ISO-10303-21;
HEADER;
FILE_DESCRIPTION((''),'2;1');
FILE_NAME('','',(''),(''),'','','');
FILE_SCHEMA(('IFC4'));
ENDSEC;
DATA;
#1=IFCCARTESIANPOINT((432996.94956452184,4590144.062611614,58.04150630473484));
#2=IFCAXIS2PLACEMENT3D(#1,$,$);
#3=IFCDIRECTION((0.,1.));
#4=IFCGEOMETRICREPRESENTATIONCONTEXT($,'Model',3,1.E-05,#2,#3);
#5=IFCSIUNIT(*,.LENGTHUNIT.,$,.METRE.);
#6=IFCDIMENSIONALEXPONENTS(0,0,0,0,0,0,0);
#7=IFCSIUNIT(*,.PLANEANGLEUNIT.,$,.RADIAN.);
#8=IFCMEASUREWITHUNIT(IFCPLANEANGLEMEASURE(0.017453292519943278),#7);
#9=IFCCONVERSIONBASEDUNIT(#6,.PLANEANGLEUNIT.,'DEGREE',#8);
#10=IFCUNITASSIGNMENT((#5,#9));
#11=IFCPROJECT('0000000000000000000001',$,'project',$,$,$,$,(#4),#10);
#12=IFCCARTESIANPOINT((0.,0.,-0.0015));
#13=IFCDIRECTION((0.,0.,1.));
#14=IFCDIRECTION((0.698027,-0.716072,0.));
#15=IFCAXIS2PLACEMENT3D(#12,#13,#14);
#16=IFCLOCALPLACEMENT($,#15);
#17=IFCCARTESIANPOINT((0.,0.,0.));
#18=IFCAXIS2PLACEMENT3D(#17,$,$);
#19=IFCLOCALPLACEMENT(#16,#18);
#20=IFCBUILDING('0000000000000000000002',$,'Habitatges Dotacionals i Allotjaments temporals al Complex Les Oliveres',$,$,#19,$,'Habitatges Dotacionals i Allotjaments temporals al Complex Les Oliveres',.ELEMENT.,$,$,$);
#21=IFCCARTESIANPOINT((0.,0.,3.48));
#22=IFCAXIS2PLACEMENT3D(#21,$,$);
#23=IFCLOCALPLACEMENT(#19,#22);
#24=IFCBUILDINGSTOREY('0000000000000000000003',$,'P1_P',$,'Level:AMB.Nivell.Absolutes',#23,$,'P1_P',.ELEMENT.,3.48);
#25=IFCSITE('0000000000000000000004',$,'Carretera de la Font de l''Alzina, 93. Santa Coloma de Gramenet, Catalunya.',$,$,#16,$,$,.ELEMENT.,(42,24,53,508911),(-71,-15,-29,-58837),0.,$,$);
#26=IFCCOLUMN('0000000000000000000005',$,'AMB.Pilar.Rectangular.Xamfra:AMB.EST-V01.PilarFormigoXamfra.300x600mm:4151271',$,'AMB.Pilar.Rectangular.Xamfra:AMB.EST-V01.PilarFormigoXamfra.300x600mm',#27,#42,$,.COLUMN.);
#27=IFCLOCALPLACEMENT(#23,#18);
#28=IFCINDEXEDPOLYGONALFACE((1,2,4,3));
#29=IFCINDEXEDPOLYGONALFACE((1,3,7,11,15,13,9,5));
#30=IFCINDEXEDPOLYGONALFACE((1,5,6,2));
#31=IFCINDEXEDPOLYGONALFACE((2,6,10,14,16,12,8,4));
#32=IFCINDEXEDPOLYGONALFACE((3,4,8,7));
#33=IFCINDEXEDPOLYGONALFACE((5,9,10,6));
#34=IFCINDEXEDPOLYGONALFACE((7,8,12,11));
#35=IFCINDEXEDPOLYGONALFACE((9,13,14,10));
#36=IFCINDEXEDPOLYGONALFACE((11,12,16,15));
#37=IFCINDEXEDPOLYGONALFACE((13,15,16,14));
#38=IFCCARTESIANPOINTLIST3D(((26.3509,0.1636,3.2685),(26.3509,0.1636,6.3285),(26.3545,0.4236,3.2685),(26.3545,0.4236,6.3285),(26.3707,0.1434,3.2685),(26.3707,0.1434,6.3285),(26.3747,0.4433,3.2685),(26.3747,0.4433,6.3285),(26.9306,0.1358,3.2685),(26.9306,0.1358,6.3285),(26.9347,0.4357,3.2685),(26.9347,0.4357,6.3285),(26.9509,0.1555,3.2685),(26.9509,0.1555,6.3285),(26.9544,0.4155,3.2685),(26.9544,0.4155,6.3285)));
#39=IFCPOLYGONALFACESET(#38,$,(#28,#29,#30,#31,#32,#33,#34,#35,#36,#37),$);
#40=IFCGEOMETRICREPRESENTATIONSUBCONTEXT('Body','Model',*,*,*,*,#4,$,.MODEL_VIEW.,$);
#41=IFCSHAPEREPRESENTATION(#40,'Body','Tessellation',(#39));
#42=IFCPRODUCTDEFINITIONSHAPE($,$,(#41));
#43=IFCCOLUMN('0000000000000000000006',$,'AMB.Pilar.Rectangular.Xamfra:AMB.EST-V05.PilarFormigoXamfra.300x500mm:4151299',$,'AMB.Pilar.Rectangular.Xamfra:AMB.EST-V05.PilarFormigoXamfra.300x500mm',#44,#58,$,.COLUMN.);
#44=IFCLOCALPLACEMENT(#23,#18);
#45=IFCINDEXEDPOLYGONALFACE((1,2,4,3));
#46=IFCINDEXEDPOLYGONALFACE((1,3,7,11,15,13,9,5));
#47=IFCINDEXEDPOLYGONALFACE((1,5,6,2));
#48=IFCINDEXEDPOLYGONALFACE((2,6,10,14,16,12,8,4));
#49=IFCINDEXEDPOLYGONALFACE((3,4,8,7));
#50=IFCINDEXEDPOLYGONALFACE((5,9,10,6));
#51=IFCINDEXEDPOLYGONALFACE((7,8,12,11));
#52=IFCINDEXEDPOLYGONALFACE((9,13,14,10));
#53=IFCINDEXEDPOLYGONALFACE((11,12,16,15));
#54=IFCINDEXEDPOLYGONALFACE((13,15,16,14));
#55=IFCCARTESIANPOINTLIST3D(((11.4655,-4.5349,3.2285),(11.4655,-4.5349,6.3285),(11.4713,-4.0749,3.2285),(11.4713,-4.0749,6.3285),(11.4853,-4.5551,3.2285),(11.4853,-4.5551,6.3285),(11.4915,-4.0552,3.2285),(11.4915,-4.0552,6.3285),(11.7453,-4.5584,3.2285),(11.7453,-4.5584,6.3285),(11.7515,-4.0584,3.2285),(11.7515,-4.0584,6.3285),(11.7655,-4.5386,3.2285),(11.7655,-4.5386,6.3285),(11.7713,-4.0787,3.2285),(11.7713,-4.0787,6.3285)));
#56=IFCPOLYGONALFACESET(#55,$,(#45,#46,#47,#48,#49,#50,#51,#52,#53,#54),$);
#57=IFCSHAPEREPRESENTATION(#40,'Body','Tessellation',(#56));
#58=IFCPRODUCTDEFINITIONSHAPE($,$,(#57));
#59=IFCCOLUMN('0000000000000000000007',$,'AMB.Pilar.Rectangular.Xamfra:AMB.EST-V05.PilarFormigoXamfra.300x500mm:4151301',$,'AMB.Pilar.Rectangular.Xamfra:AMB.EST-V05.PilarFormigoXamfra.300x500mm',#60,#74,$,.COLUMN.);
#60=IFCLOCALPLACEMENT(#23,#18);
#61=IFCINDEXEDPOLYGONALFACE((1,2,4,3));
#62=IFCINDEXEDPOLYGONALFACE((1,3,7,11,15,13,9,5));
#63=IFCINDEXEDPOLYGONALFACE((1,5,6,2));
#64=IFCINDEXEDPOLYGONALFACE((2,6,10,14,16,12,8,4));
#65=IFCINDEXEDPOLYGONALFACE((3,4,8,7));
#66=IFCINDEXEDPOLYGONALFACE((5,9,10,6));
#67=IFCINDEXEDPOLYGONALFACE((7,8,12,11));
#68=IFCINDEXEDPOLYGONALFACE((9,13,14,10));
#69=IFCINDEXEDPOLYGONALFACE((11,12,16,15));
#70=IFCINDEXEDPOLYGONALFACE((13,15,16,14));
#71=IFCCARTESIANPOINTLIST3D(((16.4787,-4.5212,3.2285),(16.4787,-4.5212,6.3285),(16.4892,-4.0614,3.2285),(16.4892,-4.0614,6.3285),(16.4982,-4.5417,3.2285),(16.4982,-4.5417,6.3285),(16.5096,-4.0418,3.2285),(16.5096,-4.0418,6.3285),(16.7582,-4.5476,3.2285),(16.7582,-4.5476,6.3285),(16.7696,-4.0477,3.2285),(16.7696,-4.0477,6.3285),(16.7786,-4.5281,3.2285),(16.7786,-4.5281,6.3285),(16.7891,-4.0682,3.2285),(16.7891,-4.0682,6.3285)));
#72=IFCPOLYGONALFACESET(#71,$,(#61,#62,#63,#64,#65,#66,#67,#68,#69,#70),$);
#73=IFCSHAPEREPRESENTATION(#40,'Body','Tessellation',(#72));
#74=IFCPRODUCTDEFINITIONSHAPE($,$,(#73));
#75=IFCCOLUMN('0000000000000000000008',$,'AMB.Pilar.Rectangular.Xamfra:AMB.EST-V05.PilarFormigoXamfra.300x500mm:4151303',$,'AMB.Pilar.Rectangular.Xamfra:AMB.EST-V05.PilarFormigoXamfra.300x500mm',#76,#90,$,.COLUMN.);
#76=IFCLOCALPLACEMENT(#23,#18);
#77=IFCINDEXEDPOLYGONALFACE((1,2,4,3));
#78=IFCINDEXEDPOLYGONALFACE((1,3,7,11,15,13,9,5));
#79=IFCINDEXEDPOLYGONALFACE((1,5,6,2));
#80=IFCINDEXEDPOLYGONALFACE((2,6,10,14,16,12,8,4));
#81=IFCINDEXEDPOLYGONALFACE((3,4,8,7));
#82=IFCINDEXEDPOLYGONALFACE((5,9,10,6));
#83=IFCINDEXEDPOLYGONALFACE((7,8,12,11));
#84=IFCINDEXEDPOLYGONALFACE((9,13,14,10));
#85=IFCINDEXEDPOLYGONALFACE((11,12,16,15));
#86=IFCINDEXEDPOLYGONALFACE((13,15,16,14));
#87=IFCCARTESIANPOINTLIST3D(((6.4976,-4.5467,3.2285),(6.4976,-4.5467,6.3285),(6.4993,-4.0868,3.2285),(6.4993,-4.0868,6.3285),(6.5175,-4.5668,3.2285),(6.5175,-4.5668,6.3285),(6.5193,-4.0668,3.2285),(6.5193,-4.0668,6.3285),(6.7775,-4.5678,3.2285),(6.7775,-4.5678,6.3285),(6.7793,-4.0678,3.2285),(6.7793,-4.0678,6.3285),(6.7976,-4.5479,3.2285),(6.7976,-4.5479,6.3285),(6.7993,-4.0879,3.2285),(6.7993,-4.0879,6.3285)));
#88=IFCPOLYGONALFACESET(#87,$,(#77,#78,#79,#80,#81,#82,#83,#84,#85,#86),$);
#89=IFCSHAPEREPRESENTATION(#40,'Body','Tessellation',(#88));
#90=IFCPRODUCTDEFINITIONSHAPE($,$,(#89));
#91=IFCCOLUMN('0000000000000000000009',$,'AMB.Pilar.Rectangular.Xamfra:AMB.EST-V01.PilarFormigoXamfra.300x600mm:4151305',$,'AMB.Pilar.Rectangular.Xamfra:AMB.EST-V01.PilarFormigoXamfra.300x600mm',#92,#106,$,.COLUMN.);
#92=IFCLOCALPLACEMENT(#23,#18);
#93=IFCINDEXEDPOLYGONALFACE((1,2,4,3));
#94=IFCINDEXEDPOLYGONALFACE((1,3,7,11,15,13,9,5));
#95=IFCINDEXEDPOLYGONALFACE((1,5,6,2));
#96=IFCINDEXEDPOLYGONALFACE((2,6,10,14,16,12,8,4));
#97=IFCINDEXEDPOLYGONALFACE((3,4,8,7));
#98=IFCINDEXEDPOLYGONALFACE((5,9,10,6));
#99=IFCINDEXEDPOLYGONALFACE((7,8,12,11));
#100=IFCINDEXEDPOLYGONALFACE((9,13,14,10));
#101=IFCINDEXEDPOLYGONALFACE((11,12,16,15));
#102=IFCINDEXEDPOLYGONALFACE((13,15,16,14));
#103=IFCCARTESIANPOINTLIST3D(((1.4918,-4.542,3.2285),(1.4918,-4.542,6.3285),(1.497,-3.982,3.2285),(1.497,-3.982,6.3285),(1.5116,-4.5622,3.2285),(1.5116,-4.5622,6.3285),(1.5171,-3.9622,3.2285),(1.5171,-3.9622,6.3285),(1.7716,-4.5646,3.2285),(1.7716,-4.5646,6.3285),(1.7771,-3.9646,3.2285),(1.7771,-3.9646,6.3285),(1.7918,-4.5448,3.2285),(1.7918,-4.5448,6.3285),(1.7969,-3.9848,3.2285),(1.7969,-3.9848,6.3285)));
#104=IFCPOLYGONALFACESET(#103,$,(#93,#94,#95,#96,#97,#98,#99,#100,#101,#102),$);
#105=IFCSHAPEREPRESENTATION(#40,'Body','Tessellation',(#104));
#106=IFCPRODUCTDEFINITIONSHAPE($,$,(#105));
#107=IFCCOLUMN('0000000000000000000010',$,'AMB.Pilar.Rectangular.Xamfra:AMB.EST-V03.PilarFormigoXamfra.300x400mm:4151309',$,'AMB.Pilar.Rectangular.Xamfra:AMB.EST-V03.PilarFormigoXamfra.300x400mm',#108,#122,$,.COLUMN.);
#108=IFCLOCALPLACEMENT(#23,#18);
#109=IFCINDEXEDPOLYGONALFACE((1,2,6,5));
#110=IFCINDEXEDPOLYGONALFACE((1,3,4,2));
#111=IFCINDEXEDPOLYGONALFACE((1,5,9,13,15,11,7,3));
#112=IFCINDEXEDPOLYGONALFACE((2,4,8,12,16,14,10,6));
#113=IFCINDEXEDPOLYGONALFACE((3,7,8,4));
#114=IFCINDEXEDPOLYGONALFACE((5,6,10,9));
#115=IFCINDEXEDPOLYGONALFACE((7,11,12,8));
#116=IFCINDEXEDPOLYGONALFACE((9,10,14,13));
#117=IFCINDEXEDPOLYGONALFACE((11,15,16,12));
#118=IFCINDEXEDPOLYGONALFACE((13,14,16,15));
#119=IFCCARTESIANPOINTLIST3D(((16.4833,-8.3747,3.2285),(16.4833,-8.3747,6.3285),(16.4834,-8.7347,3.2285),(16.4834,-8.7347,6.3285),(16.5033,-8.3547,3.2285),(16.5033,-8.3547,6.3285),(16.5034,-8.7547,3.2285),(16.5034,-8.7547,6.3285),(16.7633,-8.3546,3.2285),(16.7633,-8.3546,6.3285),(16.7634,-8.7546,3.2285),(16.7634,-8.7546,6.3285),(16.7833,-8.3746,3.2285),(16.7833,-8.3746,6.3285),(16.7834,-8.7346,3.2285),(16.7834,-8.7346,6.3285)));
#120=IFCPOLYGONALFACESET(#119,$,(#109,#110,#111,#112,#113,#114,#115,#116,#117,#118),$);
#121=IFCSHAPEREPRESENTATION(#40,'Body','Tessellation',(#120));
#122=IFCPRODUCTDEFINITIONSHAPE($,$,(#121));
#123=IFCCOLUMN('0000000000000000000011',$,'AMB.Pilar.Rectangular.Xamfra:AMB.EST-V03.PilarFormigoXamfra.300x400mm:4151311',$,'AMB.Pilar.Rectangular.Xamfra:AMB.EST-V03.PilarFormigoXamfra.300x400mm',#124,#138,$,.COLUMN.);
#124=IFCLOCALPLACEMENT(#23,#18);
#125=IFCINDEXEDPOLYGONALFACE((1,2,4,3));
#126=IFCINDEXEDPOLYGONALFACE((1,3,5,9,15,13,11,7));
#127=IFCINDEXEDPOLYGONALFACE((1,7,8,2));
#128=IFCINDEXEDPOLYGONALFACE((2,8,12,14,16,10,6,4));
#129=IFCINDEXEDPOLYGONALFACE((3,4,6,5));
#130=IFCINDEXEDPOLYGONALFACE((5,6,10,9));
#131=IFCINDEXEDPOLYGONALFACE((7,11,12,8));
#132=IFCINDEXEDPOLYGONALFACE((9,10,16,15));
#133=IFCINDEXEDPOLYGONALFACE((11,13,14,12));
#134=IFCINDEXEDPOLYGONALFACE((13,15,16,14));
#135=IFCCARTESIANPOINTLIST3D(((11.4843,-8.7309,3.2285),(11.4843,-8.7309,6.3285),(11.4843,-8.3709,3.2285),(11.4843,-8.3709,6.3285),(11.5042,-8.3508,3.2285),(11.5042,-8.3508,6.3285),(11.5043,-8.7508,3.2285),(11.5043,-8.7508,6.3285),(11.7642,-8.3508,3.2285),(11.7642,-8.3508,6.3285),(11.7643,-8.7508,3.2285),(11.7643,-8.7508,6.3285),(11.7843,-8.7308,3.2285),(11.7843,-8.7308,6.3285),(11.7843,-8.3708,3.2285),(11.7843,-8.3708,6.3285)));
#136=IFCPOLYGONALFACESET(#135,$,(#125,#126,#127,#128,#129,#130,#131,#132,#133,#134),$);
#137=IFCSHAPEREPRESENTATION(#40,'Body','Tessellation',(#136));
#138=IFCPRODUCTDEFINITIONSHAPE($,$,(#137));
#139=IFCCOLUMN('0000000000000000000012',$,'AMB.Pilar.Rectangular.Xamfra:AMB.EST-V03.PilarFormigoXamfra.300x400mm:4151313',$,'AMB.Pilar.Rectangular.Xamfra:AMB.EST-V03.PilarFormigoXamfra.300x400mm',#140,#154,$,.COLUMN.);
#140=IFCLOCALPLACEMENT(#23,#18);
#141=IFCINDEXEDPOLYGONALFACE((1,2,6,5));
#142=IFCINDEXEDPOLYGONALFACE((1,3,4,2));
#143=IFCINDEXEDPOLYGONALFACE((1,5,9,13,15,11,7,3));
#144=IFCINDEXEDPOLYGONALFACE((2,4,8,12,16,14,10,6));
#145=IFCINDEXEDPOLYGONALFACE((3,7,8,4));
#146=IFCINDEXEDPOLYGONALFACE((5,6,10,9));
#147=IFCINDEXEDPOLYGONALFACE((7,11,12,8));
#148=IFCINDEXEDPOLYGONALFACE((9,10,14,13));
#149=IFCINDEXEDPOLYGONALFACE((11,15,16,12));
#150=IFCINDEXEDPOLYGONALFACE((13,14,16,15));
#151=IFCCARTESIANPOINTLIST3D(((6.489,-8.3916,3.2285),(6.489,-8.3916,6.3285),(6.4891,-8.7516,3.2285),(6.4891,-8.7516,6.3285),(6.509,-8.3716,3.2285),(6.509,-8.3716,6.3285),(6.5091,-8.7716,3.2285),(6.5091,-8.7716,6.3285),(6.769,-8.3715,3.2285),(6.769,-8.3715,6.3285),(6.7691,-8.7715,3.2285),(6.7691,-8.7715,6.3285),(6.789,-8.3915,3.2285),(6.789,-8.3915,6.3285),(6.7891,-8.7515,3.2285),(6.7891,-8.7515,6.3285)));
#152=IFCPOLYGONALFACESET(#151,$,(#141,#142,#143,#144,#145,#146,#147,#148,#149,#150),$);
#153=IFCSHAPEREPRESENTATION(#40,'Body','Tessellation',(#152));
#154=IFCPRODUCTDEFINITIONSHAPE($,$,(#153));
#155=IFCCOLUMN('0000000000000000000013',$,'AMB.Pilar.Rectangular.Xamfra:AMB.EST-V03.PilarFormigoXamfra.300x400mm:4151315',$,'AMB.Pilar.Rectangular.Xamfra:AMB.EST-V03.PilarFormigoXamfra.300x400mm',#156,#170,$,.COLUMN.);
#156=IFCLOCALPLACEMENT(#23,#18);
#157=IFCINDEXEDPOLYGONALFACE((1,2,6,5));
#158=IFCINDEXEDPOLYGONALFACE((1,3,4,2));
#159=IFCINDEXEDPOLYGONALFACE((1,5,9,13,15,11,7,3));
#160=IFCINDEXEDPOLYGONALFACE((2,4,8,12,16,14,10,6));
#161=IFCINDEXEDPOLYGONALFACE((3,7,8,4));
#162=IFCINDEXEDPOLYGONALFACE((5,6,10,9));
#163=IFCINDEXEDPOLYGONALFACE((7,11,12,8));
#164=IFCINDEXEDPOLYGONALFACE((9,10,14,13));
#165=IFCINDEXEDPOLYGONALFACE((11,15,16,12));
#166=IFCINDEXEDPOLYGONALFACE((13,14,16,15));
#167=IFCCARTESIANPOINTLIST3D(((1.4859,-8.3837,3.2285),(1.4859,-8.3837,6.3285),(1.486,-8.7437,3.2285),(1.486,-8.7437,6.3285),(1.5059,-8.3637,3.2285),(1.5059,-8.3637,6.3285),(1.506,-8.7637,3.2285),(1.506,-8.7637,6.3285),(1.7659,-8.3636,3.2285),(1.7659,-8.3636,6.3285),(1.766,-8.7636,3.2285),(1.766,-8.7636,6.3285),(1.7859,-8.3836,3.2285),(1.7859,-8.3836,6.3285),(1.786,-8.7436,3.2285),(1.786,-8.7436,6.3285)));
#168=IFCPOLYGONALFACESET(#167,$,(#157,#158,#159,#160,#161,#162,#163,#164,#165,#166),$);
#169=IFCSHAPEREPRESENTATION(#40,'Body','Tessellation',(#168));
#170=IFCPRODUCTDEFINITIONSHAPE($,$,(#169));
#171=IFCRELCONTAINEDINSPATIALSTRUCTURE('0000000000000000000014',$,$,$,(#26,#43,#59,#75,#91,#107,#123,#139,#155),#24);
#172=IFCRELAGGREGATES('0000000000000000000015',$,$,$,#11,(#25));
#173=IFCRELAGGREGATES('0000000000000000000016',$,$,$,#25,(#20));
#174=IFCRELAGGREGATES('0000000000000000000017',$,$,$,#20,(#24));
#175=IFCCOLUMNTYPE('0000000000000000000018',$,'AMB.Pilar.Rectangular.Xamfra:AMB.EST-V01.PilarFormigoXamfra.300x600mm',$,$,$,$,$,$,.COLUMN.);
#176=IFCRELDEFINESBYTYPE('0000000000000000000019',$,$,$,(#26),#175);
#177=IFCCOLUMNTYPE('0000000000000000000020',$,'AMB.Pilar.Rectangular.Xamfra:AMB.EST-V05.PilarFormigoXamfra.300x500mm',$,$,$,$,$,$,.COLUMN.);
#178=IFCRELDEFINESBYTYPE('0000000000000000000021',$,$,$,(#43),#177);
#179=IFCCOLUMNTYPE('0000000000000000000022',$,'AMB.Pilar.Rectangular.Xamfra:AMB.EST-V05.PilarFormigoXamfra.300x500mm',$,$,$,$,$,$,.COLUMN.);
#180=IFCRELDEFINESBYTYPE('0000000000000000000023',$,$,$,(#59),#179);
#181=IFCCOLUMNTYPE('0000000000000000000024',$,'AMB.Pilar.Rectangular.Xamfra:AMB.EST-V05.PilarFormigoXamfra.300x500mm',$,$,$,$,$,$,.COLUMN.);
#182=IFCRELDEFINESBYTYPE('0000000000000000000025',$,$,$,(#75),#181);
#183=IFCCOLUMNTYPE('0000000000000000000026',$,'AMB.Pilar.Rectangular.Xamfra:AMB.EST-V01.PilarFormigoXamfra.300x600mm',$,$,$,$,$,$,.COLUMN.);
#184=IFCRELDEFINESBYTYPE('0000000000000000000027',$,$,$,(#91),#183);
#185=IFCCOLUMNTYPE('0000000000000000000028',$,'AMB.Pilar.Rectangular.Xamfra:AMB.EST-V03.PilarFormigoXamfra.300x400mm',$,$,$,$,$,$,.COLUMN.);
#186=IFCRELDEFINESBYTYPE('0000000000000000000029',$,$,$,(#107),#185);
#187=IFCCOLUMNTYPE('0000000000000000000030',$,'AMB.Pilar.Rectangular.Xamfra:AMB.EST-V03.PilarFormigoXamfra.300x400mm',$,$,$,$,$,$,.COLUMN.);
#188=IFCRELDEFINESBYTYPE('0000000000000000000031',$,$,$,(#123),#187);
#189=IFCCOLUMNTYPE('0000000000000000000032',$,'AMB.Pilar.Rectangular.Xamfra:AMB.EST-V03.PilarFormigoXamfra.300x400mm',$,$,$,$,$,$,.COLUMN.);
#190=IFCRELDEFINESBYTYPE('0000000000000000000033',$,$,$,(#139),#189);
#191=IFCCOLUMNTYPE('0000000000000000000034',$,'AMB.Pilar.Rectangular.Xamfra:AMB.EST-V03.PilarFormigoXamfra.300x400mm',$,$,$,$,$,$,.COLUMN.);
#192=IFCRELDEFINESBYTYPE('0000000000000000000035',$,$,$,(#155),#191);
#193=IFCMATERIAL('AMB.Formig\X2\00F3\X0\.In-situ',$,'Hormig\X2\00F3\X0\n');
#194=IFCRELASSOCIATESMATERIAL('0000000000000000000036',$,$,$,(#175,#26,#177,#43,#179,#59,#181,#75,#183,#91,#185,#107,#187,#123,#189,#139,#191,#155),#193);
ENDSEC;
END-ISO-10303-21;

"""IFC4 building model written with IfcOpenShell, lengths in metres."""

from ifc_helpers import new_model, entity, si_unit, converted_unit, direction, frame, origin, place, context, subcontext, project, spatial, indexed_curve, outline, extrude, source, transform, mapped, material, type_object, type_shapes, element, save


model = new_model("IFC4")

# Units and contexts
model_context = context("Model", 3, precision=1e-05, world=frame((432996.94956452184, 4590144.062611614, 58.04150630473484)), true_north=direction((0.0, 1.0)))
body_context = subcontext(model_context, "Body", "Model", "MODEL_VIEW")
ifc_project = project(units=[si_unit("LENGTHUNIT", "METRE"), converted_unit("PLANEANGLEUNIT", "DEGREE", entity("IfcPlaneAngleMeasure", 0.017453292519943278), si_unit("PLANEANGLEUNIT", "RADIAN"), dimensions=[0, 0, 0, 0, 0, 0, 0])], contexts=[model_context])

# Site, building, storey
site_placement = place(None, frame((0.0, 0.0, -0.0015), z_axis=(0.0, 0.0, 1.0), x_axis=(0.698027, -0.716072, 0.0)))
site = spatial("IfcSite", under=ifc_project, at=site_placement, Name="Carretera de la Font de l'Alzina, 93. Santa Coloma de Gramenet, Catalunya.", CompositionType="ELEMENT", RefLatitude=(42, 24, 53, 508911), RefLongitude=(-71, -15, -29, -58837), RefElevation=0.0)
building_placement = place(site_placement, origin())
building = spatial("IfcBuilding", under=site, at=building_placement, Name="Habitatges Dotacionals i Allotjaments temporals al Complex Les Oliveres", LongName="Habitatges Dotacionals i Allotjaments temporals al Complex Les Oliveres", CompositionType="ELEMENT")
storey_placement = place(building_placement, frame((0.0, 0.0, 3.48)))
storey = spatial("IfcBuildingStorey", under=building, at=storey_placement, Name="P1_P", ObjectType="Level:AMB.Nivell.Absolutes", LongName="P1_P", CompositionType="ELEMENT", Elevation=3.48)

# Columns
ifc_material = material(Name="AMB.Formigó.In-situ", Category="Hormigón")
column_type_1 = type_object("IfcColumnType", Name="AMB.Pilar.Rectangular.Xamfra:AMB.EST-V01.PilarFormigoXamfra.300x600mm", PredefinedType="COLUMN", material=ifc_material)
shared_shape_1 = source(origin(), body_context, "Body", "SweptSolid", [
    extrude(outline(indexed_curve([(-0.13, -0.3), (0.13, -0.3), (0.15, -0.28), (0.15, 0.28), (0.13, 0.3), (-0.13, 0.3), (-0.15, 0.28), (-0.15, -0.28), (-0.13, -0.3)], self_intersect=False)), frame((26.6527, 0.2896, 6.7485), z_axis=(0.0, 0.0, 1.0), x_axis=(0.013579, 0.999908, 0.0)), (0.0, 0.0, 1.0), 3.06),
])
type_shapes(column_type_1, [shared_shape_1])
column_1_placement = place(storey_placement, frame((0.0, 0.0, -3.48)))
element("IfcColumn", 1, at=column_1_placement, inside=storey, type_object=column_type_1, material=ifc_material, Name="AMB.Pilar.Rectangular.Xamfra:AMB.EST-V01.PilarFormigoXamfra.300x600mm:4151271", ObjectType="AMB.Pilar.Rectangular.Xamfra:AMB.EST-V01.PilarFormigoXamfra.300x600mm", PredefinedType="COLUMN", context=body_context, shape_type="MappedRepresentation", body=[
    mapped(shared_shape_1, transform((0.0, 0.0, 0.0), scale=1.0)),
])
column_type_2 = type_object("IfcColumnType", Name="AMB.Pilar.Rectangular.Xamfra:AMB.EST-V05.PilarFormigoXamfra.300x500mm", PredefinedType="COLUMN", material=ifc_material)
shared_shape_2 = source(origin(), body_context, "Body", "SweptSolid", [
    extrude(outline(indexed_curve([(-0.13, -0.25), (0.13, -0.25), (0.15, -0.23), (0.15, 0.23), (0.13, 0.25), (-0.13, 0.25), (-0.15, 0.23), (-0.15, -0.23), (-0.13, -0.25)], self_intersect=False)), frame((11.6184, -4.3068, 6.7085), z_axis=(0.0, 0.0, 1.0), x_axis=(-0.999922, 0.012529, 0.0)), (0.0, 0.0, 1.0), 3.1),
])
type_shapes(column_type_2, [shared_shape_2])
column_2_placement = place(storey_placement, frame((0.0, 0.0, -3.48)))
element("IfcColumn", 2, at=column_2_placement, inside=storey, type_object=column_type_2, material=ifc_material, Name="AMB.Pilar.Rectangular.Xamfra:AMB.EST-V05.PilarFormigoXamfra.300x500mm:4151299", ObjectType="AMB.Pilar.Rectangular.Xamfra:AMB.EST-V05.PilarFormigoXamfra.300x500mm", PredefinedType="COLUMN", context=body_context, shape_type="MappedRepresentation", body=[
    mapped(shared_shape_2, transform((0.0, 0.0, 0.0), scale=1.0)),
])
column_type_3 = type_object("IfcColumnType", Name="AMB.Pilar.Rectangular.Xamfra:AMB.EST-V05.PilarFormigoXamfra.300x500mm", PredefinedType="COLUMN", material=ifc_material)
shared_shape_3 = source(origin(), body_context, "Body", "SweptSolid", [
    extrude(outline(indexed_curve([(-0.13, -0.25), (0.13, -0.25), (0.15, -0.23), (0.15, 0.23), (0.13, 0.25), (-0.13, 0.25), (-0.15, 0.23), (-0.15, -0.23), (-0.13, -0.25)], self_intersect=False)), frame((16.6339, -4.2947, 6.7085), z_axis=(0.0, 0.0, 1.0), x_axis=(-0.99974, 0.022817, 0.0)), (0.0, 0.0, 1.0), 3.1),
])
type_shapes(column_type_3, [shared_shape_3])
column_3_placement = place(storey_placement, frame((0.0, 0.0, -3.48)))
element("IfcColumn", 3, at=column_3_placement, inside=storey, type_object=column_type_3, material=ifc_material, Name="AMB.Pilar.Rectangular.Xamfra:AMB.EST-V05.PilarFormigoXamfra.300x500mm:4151301", ObjectType="AMB.Pilar.Rectangular.Xamfra:AMB.EST-V05.PilarFormigoXamfra.300x500mm", PredefinedType="COLUMN", context=body_context, shape_type="MappedRepresentation", body=[
    mapped(shared_shape_3, transform((0.0, 0.0, 0.0), scale=1.0)),
])
column_type_4 = type_object("IfcColumnType", Name="AMB.Pilar.Rectangular.Xamfra:AMB.EST-V05.PilarFormigoXamfra.300x500mm", PredefinedType="COLUMN", material=ifc_material)
shared_shape_4 = source(origin(), body_context, "Body", "SweptSolid", [
    extrude(outline(indexed_curve([(-0.13, -0.25), (0.13, -0.25), (0.15, -0.23), (0.15, 0.23), (0.13, 0.25), (-0.13, 0.25), (-0.15, 0.23), (-0.15, -0.23), (-0.13, -0.25)], self_intersect=False)), frame((6.6484, -4.3173, 6.7085), z_axis=(0.0, 0.0, 1.0), x_axis=(-0.999993, 0.003691, 0.0)), (0.0, 0.0, 1.0), 3.1),
])
type_shapes(column_type_4, [shared_shape_4])
column_4_placement = place(storey_placement, frame((0.0, 0.0, -3.48)))
element("IfcColumn", 4, at=column_4_placement, inside=storey, type_object=column_type_4, material=ifc_material, Name="AMB.Pilar.Rectangular.Xamfra:AMB.EST-V05.PilarFormigoXamfra.300x500mm:4151303", ObjectType="AMB.Pilar.Rectangular.Xamfra:AMB.EST-V05.PilarFormigoXamfra.300x500mm", PredefinedType="COLUMN", context=body_context, shape_type="MappedRepresentation", body=[
    mapped(shared_shape_4, transform((0.0, 0.0, 0.0), scale=1.0)),
])
column_type_5 = type_object("IfcColumnType", Name="AMB.Pilar.Rectangular.Xamfra:AMB.EST-V01.PilarFormigoXamfra.300x600mm", PredefinedType="COLUMN", material=ifc_material)
shared_shape_5 = source(origin(), body_context, "Body", "SweptSolid", [
    extrude(outline(indexed_curve([(-0.13, -0.3), (0.13, -0.3), (0.15, -0.28), (0.15, 0.28), (0.13, 0.3), (-0.13, 0.3), (-0.15, 0.28), (-0.15, -0.28), (-0.13, -0.3)], self_intersect=False)), frame((1.6444, -4.2634, 6.7085), z_axis=(0.0, 0.0, 1.0), x_axis=(-0.999957, 0.009259, 0.0)), (0.0, 0.0, 1.0), 3.1),
])
type_shapes(column_type_5, [shared_shape_5])
column_5_placement = place(storey_placement, frame((0.0, 0.0, -3.48)))
element("IfcColumn", 5, at=column_5_placement, inside=storey, type_object=column_type_5, material=ifc_material, Name="AMB.Pilar.Rectangular.Xamfra:AMB.EST-V01.PilarFormigoXamfra.300x600mm:4151305", ObjectType="AMB.Pilar.Rectangular.Xamfra:AMB.EST-V01.PilarFormigoXamfra.300x600mm", PredefinedType="COLUMN", context=body_context, shape_type="MappedRepresentation", body=[
    mapped(shared_shape_5, transform((0.0, 0.0, 0.0), scale=1.0)),
])
column_type_6 = type_object("IfcColumnType", Name="AMB.Pilar.Rectangular.Xamfra:AMB.EST-V03.PilarFormigoXamfra.300x400mm", PredefinedType="COLUMN", material=ifc_material)
shared_shape_6 = source(origin(), body_context, "Body", "SweptSolid", [
    extrude(outline(indexed_curve([(-0.13, -0.2), (0.13, -0.2), (0.15, -0.18), (0.15, 0.18), (0.13, 0.2), (-0.13, 0.2), (-0.15, 0.18), (-0.15, -0.18), (-0.13, -0.2)], self_intersect=False)), frame((16.6333, -8.5547, 6.7085), z_axis=(0.0, 0.0, 1.0), x_axis=(1.0, 0.000195, 0.0)), (0.0, 0.0, 1.0), 3.1),
])
type_shapes(column_type_6, [shared_shape_6])
column_6_placement = place(storey_placement, frame((0.0, 0.0, -3.48)))
element("IfcColumn", 6, at=column_6_placement, inside=storey, type_object=column_type_6, material=ifc_material, Name="AMB.Pilar.Rectangular.Xamfra:AMB.EST-V03.PilarFormigoXamfra.300x400mm:4151309", ObjectType="AMB.Pilar.Rectangular.Xamfra:AMB.EST-V03.PilarFormigoXamfra.300x400mm", PredefinedType="COLUMN", context=body_context, shape_type="MappedRepresentation", body=[
    mapped(shared_shape_6, transform((0.0, 0.0, 0.0), scale=1.0)),
])
column_type_7 = type_object("IfcColumnType", Name="AMB.Pilar.Rectangular.Xamfra:AMB.EST-V03.PilarFormigoXamfra.300x400mm", PredefinedType="COLUMN", material=ifc_material)
shared_shape_7 = source(origin(), body_context, "Body", "SweptSolid", [
    extrude(outline(indexed_curve([(-0.13, -0.2), (0.13, -0.2), (0.15, -0.18), (0.15, 0.18), (0.13, 0.2), (-0.13, 0.2), (-0.15, 0.18), (-0.15, -0.18), (-0.13, -0.2)], self_intersect=False)), frame((11.6343, -8.5508, 6.7085), z_axis=(0.0, 0.0, 1.0), x_axis=(1.0, 0.000195, 0.0)), (0.0, 0.0, 1.0), 3.1),
])
type_shapes(column_type_7, [shared_shape_7])
column_7_placement = place(storey_placement, frame((0.0, 0.0, -3.48)))
element("IfcColumn", 7, at=column_7_placement, inside=storey, type_object=column_type_7, material=ifc_material, Name="AMB.Pilar.Rectangular.Xamfra:AMB.EST-V03.PilarFormigoXamfra.300x400mm:4151311", ObjectType="AMB.Pilar.Rectangular.Xamfra:AMB.EST-V03.PilarFormigoXamfra.300x400mm", PredefinedType="COLUMN", context=body_context, shape_type="MappedRepresentation", body=[
    mapped(shared_shape_7, transform((0.0, 0.0, 0.0), scale=1.0)),
])
column_type_8 = type_object("IfcColumnType", Name="AMB.Pilar.Rectangular.Xamfra:AMB.EST-V03.PilarFormigoXamfra.300x400mm", PredefinedType="COLUMN", material=ifc_material)
shared_shape_8 = source(origin(), body_context, "Body", "SweptSolid", [
    extrude(outline(indexed_curve([(-0.13, -0.2), (0.13, -0.2), (0.15, -0.18), (0.15, 0.18), (0.13, 0.2), (-0.13, 0.2), (-0.15, 0.18), (-0.15, -0.18), (-0.13, -0.2)], self_intersect=False)), frame((6.639, -8.5716, 6.7085), z_axis=(0.0, 0.0, 1.0), x_axis=(1.0, 0.000195, 0.0)), (0.0, 0.0, 1.0), 3.1),
])
type_shapes(column_type_8, [shared_shape_8])
column_8_placement = place(storey_placement, frame((0.0, 0.0, -3.48)))
element("IfcColumn", 8, at=column_8_placement, inside=storey, type_object=column_type_8, material=ifc_material, Name="AMB.Pilar.Rectangular.Xamfra:AMB.EST-V03.PilarFormigoXamfra.300x400mm:4151313", ObjectType="AMB.Pilar.Rectangular.Xamfra:AMB.EST-V03.PilarFormigoXamfra.300x400mm", PredefinedType="COLUMN", context=body_context, shape_type="MappedRepresentation", body=[
    mapped(shared_shape_8, transform((0.0, 0.0, 0.0), scale=1.0)),
])
column_type_9 = type_object("IfcColumnType", Name="AMB.Pilar.Rectangular.Xamfra:AMB.EST-V03.PilarFormigoXamfra.300x400mm", PredefinedType="COLUMN", material=ifc_material)
shared_shape_9 = source(origin(), body_context, "Body", "SweptSolid", [
    extrude(outline(indexed_curve([(-0.13, -0.2), (0.13, -0.2), (0.15, -0.18), (0.15, 0.18), (0.13, 0.2), (-0.13, 0.2), (-0.15, 0.18), (-0.15, -0.18), (-0.13, -0.2)], self_intersect=False)), frame((1.6359, -8.5637, 6.7085), z_axis=(0.0, 0.0, 1.0), x_axis=(1.0, 0.000195, 0.0)), (0.0, 0.0, 1.0), 3.1),
])
type_shapes(column_type_9, [shared_shape_9])
column_9_placement = place(storey_placement, frame((0.0, 0.0, -3.48)))
element("IfcColumn", 9, at=column_9_placement, inside=storey, type_object=column_type_9, material=ifc_material, Name="AMB.Pilar.Rectangular.Xamfra:AMB.EST-V03.PilarFormigoXamfra.300x400mm:4151315", ObjectType="AMB.Pilar.Rectangular.Xamfra:AMB.EST-V03.PilarFormigoXamfra.300x400mm", PredefinedType="COLUMN", context=body_context, shape_type="MappedRepresentation", body=[
    mapped(shared_shape_9, transform((0.0, 0.0, 0.0), scale=1.0)),
])

save(model, "model.ifc")
